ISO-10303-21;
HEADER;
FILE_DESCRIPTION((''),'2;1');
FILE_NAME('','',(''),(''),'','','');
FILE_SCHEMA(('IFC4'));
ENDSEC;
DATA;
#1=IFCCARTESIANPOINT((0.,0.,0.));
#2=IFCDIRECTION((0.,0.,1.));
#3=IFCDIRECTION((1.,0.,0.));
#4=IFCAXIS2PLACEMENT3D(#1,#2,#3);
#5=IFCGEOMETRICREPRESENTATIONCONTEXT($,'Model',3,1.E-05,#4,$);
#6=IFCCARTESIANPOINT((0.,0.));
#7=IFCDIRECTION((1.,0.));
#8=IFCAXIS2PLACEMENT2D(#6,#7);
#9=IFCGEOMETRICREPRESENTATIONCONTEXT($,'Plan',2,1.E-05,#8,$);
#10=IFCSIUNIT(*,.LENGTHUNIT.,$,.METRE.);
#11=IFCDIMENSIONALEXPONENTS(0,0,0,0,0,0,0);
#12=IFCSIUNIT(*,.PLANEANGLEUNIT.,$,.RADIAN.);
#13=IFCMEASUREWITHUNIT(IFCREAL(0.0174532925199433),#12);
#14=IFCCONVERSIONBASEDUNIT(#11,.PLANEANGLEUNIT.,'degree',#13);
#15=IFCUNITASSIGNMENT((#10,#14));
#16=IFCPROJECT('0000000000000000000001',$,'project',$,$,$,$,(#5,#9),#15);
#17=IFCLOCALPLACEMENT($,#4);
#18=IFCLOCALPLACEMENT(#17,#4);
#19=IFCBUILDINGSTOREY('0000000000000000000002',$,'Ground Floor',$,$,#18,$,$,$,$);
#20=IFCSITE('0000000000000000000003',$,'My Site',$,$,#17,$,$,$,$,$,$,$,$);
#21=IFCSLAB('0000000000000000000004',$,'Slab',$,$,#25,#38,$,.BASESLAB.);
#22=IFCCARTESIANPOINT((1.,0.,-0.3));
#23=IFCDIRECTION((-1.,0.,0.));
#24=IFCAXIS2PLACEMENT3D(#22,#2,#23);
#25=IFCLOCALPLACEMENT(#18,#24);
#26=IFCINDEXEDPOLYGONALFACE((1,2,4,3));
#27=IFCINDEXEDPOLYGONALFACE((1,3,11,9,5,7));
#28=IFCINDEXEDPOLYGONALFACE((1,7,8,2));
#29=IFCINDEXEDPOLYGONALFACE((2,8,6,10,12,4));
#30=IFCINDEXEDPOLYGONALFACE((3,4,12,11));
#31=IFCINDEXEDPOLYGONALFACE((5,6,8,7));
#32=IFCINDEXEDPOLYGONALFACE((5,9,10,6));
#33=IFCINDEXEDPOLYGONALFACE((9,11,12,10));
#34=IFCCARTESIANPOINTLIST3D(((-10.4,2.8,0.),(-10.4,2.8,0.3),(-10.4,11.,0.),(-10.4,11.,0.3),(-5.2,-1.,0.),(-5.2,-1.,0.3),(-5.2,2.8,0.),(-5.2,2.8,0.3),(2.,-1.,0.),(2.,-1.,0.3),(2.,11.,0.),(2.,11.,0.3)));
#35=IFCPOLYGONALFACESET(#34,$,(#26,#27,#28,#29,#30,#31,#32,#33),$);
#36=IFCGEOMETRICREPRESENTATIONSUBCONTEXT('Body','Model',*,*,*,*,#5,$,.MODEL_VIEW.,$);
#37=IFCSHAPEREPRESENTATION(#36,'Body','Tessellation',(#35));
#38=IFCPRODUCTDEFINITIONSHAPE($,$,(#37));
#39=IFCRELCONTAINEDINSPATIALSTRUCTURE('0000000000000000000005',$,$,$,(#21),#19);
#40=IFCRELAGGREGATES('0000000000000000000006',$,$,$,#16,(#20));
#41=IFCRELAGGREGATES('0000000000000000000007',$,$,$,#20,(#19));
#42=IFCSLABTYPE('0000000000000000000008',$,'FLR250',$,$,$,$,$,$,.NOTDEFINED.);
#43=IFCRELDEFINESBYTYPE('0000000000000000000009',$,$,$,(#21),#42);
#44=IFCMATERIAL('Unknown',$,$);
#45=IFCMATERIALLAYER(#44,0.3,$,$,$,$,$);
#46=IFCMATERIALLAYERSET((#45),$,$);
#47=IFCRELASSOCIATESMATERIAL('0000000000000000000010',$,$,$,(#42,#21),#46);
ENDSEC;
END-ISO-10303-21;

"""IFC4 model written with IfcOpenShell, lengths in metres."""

from ifc_helpers import new_model, entity, si_unit, converted_unit, frame, origin_with_axes, origin_2d_with_axis, place, context, subcontext, project, spatial, line, indexed_curve, outline, extrude, material, layer, layer_set, layer_usage, type_object, element, save


model = new_model("IFC4")

# Units and contexts
model_context = context("Model", 3, precision=1e-05, world=origin_with_axes())
plan_context = context("Plan", 2, precision=1e-05, world=origin_2d_with_axis())
body_context = subcontext(model_context, "Body", "Model", "MODEL_VIEW")
ifc_project = project(units=[si_unit("LENGTHUNIT", "METRE"), converted_unit("PLANEANGLEUNIT", "degree", entity("IfcReal", 0.0174532925199433), si_unit("PLANEANGLEUNIT", "RADIAN"), dimensions=[0, 0, 0, 0, 0, 0, 0])], contexts=[model_context, plan_context])

# Site, storey
site_placement = place(None, origin_with_axes())
site = spatial("IfcSite", under=ifc_project, at=site_placement, Name="My Site")
storey_placement = place(site_placement, origin_with_axes())
storey = spatial("IfcBuildingStorey", under=site, at=storey_placement, Name="Ground Floor")

# Slab
ifc_material = material(Name="Unknown")
ifc_layer_1 = layer(ifc_material, 0.3)
ifc_layer_set_1 = layer_set([ifc_layer_1])
ifc_layer_usage_1 = layer_usage(ifc_layer_set_1, "AXIS3", "POSITIVE", 0.0)
slab_type = type_object("IfcSlabType", Name="FLR250", PredefinedType="NOTDEFINED", material=ifc_layer_set_1)
slab_placement = place(storey_placement, frame((1.0, 0.0, -0.3), z_axis=(0.0, 0.0, 1.0), x_axis=(-1.0, 0.0, 0.0)))
element("IfcSlab", 1, at=slab_placement, inside=storey, type_object=slab_type, material=ifc_layer_usage_1, Name="Slab", PredefinedType="BASESLAB", context=body_context, shape_type="SweptSolid", body=[
    extrude(outline(indexed_curve([(2.0, -1.0), (2.0, 11.0), (-10.4, 11.0), (-10.4, 2.8), (-5.2, 2.8), (-5.2, -1.0)], segments=[line(5, 4), line(4, 3), line(3, 2), line(2, 1), line(1, 6), line(6, 5)], self_intersect=False)), origin_with_axes(), (0.0, 0.0, 1.0), 0.3),
])

save(model, "model.ifc")
